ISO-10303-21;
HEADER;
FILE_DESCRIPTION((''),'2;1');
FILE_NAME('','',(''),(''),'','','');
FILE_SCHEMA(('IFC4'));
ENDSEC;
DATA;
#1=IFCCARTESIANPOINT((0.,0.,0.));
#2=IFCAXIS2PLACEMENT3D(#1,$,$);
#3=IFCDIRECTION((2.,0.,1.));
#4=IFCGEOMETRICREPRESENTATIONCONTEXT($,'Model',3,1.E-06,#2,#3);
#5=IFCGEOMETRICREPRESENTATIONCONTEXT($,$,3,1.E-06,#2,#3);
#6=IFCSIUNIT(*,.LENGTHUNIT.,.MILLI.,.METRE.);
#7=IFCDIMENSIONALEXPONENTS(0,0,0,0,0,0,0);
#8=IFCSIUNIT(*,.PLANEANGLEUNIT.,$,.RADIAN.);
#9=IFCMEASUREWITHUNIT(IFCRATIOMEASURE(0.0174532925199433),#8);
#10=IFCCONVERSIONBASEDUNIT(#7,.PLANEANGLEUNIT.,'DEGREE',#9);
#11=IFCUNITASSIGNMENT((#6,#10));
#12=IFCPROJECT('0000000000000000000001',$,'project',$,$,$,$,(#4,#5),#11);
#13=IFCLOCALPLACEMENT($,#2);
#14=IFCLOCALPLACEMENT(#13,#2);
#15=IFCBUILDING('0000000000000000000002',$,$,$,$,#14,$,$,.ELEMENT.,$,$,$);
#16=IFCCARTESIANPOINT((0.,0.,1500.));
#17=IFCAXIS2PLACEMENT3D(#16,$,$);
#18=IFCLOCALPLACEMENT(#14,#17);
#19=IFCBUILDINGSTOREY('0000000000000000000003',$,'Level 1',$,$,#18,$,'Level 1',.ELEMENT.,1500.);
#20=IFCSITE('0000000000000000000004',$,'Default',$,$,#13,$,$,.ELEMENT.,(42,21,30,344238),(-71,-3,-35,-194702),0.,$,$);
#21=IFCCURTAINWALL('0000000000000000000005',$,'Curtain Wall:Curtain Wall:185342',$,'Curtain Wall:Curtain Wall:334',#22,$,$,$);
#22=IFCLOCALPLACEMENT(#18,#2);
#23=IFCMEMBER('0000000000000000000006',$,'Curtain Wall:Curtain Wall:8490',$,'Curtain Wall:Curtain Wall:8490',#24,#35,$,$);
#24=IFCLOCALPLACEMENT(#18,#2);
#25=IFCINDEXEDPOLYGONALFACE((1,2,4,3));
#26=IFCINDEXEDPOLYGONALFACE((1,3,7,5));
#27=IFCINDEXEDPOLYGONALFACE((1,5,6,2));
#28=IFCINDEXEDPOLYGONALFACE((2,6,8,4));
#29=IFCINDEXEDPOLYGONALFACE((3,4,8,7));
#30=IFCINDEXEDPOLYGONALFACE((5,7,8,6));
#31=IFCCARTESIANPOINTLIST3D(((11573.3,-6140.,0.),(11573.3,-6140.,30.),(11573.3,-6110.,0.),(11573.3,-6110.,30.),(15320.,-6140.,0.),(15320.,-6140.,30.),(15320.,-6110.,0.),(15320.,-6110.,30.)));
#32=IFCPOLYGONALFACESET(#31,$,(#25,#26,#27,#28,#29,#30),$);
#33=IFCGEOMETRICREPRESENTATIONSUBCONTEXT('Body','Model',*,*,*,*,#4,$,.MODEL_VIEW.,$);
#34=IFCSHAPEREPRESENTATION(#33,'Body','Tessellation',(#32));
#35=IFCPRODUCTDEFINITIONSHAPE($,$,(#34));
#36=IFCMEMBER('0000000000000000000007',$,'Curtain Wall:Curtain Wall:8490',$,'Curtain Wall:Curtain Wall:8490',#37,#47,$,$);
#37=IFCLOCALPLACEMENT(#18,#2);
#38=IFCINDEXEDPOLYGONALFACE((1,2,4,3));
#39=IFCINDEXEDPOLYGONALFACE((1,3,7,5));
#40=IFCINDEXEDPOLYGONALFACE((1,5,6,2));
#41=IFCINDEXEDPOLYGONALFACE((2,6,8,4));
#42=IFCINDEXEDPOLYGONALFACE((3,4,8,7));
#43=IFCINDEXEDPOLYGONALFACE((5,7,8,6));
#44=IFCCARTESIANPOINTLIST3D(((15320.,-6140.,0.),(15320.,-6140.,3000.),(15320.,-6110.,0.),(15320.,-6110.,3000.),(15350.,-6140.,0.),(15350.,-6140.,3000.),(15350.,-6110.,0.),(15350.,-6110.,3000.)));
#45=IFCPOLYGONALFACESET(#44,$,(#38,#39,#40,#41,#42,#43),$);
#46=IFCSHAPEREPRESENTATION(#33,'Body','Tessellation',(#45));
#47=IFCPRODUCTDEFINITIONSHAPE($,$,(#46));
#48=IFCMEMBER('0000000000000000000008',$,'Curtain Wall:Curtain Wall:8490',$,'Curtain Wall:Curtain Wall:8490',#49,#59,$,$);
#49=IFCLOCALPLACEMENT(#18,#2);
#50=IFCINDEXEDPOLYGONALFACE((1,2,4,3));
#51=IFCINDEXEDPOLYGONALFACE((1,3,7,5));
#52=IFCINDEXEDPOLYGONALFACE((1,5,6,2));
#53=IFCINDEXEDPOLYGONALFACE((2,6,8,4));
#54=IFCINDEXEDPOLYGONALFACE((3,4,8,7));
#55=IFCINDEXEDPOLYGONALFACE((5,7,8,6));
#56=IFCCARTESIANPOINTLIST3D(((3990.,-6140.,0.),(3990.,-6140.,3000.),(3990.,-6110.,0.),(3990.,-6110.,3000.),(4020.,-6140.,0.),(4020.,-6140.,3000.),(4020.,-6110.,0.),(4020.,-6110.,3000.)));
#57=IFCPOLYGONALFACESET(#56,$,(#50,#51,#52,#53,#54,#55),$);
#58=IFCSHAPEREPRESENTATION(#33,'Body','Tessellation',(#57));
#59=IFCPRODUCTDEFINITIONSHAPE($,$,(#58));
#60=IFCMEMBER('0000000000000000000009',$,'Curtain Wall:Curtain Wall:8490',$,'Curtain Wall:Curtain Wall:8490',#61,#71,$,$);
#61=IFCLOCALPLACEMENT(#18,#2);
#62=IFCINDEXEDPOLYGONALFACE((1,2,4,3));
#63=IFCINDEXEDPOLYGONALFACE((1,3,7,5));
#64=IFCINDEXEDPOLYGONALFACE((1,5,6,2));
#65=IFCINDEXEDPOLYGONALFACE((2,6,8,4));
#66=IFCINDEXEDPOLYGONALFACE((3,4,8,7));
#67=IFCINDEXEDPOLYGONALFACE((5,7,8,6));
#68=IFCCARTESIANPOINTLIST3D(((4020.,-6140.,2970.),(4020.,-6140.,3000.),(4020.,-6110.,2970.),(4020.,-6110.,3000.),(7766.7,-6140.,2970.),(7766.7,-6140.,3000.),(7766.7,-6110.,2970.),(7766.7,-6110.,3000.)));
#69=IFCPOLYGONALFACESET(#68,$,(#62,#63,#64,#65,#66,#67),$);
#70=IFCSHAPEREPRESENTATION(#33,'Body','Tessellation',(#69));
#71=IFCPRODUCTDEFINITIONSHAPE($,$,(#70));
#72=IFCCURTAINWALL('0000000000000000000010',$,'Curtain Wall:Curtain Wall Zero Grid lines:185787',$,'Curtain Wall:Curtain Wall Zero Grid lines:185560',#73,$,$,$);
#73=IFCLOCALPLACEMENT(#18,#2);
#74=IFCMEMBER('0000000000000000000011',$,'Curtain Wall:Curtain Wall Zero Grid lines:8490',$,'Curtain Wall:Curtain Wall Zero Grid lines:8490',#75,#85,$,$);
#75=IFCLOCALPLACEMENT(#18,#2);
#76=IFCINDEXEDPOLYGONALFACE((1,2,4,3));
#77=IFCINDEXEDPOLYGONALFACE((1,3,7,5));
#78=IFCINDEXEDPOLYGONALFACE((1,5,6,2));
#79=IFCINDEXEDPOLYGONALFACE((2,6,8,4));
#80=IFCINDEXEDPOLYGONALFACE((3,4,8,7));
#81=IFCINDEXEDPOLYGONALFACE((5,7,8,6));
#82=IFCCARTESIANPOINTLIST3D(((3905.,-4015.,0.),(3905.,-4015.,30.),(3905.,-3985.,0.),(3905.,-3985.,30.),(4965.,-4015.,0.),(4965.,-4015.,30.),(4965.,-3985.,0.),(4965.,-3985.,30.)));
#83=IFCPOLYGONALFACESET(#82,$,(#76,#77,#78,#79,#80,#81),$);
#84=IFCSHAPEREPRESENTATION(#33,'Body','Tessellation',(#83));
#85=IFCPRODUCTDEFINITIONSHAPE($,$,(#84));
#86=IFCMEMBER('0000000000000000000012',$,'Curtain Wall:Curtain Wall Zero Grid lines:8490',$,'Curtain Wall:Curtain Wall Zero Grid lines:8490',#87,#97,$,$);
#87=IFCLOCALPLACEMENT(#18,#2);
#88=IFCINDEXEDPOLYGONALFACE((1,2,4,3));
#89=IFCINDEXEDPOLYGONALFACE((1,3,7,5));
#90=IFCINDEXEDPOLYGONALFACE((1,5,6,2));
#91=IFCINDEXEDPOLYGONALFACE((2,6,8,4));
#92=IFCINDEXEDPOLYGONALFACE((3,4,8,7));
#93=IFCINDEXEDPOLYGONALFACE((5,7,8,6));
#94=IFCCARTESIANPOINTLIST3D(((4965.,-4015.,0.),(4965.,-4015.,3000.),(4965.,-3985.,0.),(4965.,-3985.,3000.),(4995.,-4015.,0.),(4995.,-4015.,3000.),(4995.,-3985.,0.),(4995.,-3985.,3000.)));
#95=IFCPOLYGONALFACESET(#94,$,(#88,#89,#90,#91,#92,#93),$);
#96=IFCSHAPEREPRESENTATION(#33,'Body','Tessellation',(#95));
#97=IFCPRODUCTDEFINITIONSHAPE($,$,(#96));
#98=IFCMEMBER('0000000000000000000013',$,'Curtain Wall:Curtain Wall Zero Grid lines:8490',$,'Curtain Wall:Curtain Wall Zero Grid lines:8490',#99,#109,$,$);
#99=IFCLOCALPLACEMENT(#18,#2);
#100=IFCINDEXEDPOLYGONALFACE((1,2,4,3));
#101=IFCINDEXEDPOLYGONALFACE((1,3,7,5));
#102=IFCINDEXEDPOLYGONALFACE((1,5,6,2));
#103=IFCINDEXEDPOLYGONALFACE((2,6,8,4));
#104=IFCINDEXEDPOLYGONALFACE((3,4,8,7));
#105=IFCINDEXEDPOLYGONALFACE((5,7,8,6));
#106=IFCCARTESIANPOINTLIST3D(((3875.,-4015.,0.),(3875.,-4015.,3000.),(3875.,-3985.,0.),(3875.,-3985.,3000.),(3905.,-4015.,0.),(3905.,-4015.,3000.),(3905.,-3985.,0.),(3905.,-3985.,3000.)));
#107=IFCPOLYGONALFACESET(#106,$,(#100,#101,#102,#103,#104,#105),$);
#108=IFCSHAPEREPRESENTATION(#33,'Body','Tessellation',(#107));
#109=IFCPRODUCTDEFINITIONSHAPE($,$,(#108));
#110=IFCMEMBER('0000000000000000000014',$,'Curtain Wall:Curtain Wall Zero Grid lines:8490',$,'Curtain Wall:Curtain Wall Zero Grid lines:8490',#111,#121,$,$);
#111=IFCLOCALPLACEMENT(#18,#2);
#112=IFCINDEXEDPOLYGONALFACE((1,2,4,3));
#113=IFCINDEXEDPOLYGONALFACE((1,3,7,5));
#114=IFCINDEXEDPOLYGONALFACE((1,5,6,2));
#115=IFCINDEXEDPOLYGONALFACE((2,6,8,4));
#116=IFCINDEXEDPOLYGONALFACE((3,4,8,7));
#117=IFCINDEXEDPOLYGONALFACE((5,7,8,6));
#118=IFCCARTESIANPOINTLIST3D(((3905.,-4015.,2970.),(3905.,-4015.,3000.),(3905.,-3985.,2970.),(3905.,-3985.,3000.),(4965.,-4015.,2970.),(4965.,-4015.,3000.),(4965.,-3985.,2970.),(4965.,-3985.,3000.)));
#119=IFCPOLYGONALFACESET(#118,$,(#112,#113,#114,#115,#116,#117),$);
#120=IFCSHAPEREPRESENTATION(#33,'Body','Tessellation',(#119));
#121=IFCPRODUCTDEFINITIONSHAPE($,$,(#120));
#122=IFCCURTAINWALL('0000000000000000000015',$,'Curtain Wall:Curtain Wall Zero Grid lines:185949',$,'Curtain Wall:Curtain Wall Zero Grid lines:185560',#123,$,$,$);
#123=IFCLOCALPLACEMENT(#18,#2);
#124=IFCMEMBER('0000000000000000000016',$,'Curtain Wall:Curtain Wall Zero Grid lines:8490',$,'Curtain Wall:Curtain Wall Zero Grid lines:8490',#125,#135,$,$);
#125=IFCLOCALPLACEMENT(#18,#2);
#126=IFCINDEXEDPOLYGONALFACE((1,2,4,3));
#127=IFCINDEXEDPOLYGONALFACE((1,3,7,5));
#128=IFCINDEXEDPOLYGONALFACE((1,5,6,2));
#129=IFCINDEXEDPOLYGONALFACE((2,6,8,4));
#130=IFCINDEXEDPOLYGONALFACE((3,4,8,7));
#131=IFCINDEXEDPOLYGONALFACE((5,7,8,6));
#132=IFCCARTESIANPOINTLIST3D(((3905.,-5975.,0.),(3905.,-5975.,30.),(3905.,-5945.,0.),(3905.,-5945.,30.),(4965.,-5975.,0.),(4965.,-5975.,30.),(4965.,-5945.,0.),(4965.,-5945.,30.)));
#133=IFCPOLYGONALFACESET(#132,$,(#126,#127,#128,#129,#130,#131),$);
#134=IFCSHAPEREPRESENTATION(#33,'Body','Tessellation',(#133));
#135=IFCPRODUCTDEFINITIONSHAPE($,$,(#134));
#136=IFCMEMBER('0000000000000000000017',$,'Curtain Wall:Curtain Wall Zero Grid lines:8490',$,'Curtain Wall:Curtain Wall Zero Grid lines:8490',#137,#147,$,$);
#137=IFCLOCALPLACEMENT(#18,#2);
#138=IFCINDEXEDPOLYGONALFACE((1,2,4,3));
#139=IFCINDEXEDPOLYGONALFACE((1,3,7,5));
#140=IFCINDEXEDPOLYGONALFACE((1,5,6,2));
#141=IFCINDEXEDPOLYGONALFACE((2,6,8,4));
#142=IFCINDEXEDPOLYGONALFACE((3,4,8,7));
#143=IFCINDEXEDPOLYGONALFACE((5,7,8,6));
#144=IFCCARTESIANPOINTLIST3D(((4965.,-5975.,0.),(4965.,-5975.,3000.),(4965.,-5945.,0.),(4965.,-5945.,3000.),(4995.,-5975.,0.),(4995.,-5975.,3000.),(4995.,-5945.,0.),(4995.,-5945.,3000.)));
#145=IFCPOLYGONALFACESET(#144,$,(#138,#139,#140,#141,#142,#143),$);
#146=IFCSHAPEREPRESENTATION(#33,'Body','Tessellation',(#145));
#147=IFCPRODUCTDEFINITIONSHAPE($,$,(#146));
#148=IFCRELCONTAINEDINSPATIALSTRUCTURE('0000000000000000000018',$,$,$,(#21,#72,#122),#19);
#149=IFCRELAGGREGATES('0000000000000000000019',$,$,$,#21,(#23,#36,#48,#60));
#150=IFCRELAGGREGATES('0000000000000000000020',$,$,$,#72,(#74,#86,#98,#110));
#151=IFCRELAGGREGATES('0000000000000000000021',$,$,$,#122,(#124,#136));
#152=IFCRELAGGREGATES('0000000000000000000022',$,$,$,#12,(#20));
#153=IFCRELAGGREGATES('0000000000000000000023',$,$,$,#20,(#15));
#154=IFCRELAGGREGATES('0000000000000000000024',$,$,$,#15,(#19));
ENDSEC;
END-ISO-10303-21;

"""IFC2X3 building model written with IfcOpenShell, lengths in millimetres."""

from ifc_helpers import new_model, entity, si_unit, converted_unit, direction, frame, frame_2d, origin, place, context, subcontext, project, spatial, rectangle, extrude, element, aggregate, save


model = new_model("IFC2X3")

# Units and contexts
model_context = context("Model", 3, precision=1e-06, world=origin(), true_north=direction((2.0, 0.0, 1.0)))
context_of_model = context(None, 3, precision=1e-06, world=origin(), true_north=direction((2.0, 0.0, 1.0)))
body_context = subcontext(model_context, "Body", "Model", "MODEL_VIEW")
ifc_project = project(units=[si_unit("LENGTHUNIT", "METRE", prefix="MILLI"), converted_unit("PLANEANGLEUNIT", "DEGREE", entity("IfcRatioMeasure", 0.0174532925199433), si_unit("PLANEANGLEUNIT", "RADIAN"), dimensions=[0, 0, 0, 0, 0, 0, 0])], contexts=[model_context, context_of_model])

# Site, building, storey
site_placement = place(None, origin())
site = spatial("IfcSite", under=ifc_project, at=site_placement, Name="Default", CompositionType="ELEMENT", RefLatitude=(42, 21, 30, 344238), RefLongitude=(-71, -3, -35, -194702), RefElevation=0.0)
building_placement = place(site_placement, origin())
building = spatial("IfcBuilding", under=site, at=building_placement, CompositionType="ELEMENT")
storey_placement = place(building_placement, frame((0.0, 0.0, 1500.0)))
storey = spatial("IfcBuildingStorey", under=building, at=storey_placement, Name="Level 1", LongName="Level 1", CompositionType="ELEMENT", Elevation=1500.0)

# Curtain walls, members
curtain_wall_1_placement = place(storey_placement, origin())
curtain_wall_1 = element("IfcCurtainWall", 1, at=curtain_wall_1_placement, inside=storey, Name="Curtain Wall:Curtain Wall:185342", ObjectType="Curtain Wall:Curtain Wall:334")
member_1_placement = place(storey_placement, origin())
member_1 = element("IfcMember", 2, at=member_1_placement, Name="Curtain Wall:Curtain Wall:8490", ObjectType="Curtain Wall:Curtain Wall:8490", context=body_context, shape_type="SweptSolid", body=[
    extrude(rectangle(XDim=3746.7, YDim=30.0, at=frame_2d((0.0, 0.0), x_axis=(1.0, 0.0))), frame((13446.7, -6125.0, 0.0), z_axis=(0.0, 0.0, 1.0), x_axis=(-1.0, 0.0, 0.0)), (0.0, 0.0, 1.0), 30.0),
])
member_2_placement = place(storey_placement, origin())
member_2 = element("IfcMember", 3, at=member_2_placement, Name="Curtain Wall:Curtain Wall:8490", ObjectType="Curtain Wall:Curtain Wall:8490", context=body_context, shape_type="SweptSolid", body=[
    extrude(rectangle(XDim=30.0, YDim=30.0, at=frame_2d((0.0, 0.0), x_axis=(1.0, 0.0))), frame((15335.0, -6125.0, 0.0), z_axis=(0.0, 0.0, 1.0), x_axis=(-1.0, 0.0, 0.0)), (0.0, 0.0, 1.0), 3000.0),
])
member_3_placement = place(storey_placement, origin())
member_3 = element("IfcMember", 4, at=member_3_placement, Name="Curtain Wall:Curtain Wall:8490", ObjectType="Curtain Wall:Curtain Wall:8490", context=body_context, shape_type="SweptSolid", body=[
    extrude(rectangle(XDim=30.0, YDim=30.0, at=frame_2d((0.0, 0.0), x_axis=(1.0, 0.0))), frame((4005.0, -6125.0, 0.0), z_axis=(0.0, 0.0, 1.0), x_axis=(0.0, -1.0, 0.0)), (0.0, 0.0, 1.0), 3000.0),
])
member_4_placement = place(storey_placement, origin())
member_4 = element("IfcMember", 5, at=member_4_placement, Name="Curtain Wall:Curtain Wall:8490", ObjectType="Curtain Wall:Curtain Wall:8490", context=body_context, shape_type="SweptSolid", body=[
    extrude(rectangle(XDim=3746.7, YDim=30.0, at=frame_2d((0.0, 0.0), x_axis=(1.0, 0.0))), frame((5893.3, -6125.0, 2970.0)), (0.0, 0.0, 1.0), 30.0),
])
aggregate(curtain_wall_1, [member_1, member_2, member_3, member_4])
curtain_wall_2_placement = place(storey_placement, origin())
curtain_wall_2 = element("IfcCurtainWall", 6, at=curtain_wall_2_placement, inside=storey, Name="Curtain Wall:Curtain Wall Zero Grid lines:185787", ObjectType="Curtain Wall:Curtain Wall Zero Grid lines:185560")
member_5_placement = place(storey_placement, origin())
member_5 = element("IfcMember", 7, at=member_5_placement, Name="Curtain Wall:Curtain Wall Zero Grid lines:8490", ObjectType="Curtain Wall:Curtain Wall Zero Grid lines:8490", context=body_context, shape_type="SweptSolid", body=[
    extrude(rectangle(XDim=1060.0, YDim=30.0, at=frame_2d((0.0, 0.0), x_axis=(1.0, 0.0))), frame((4435.0, -4000.0, 0.0)), (0.0, 0.0, 1.0), 30.0),
])
member_6_placement = place(storey_placement, origin())
member_6 = element("IfcMember", 8, at=member_6_placement, Name="Curtain Wall:Curtain Wall Zero Grid lines:8490", ObjectType="Curtain Wall:Curtain Wall Zero Grid lines:8490", context=body_context, shape_type="SweptSolid", body=[
    extrude(rectangle(XDim=30.0, YDim=30.0, at=frame_2d((0.0, 0.0), x_axis=(1.0, 0.0))), frame((4980.0, -4000.0, 0.0), z_axis=(0.0, 0.0, 1.0), x_axis=(0.0, 1.0, 0.0)), (0.0, 0.0, 1.0), 3000.0),
])
member_7_placement = place(storey_placement, origin())
member_7 = element("IfcMember", 9, at=member_7_placement, Name="Curtain Wall:Curtain Wall Zero Grid lines:8490", ObjectType="Curtain Wall:Curtain Wall Zero Grid lines:8490", context=body_context, shape_type="SweptSolid", body=[
    extrude(rectangle(XDim=30.0, YDim=30.0, at=frame_2d((0.0, 0.0), x_axis=(1.0, 0.0))), frame((3890.0, -4000.0, 0.0)), (0.0, 0.0, 1.0), 3000.0),
])
member_8_placement = place(storey_placement, origin())
member_8 = element("IfcMember", 10, at=member_8_placement, Name="Curtain Wall:Curtain Wall Zero Grid lines:8490", ObjectType="Curtain Wall:Curtain Wall Zero Grid lines:8490", context=body_context, shape_type="SweptSolid", body=[
    extrude(rectangle(XDim=1060.0, YDim=30.0, at=frame_2d((0.0, 0.0), x_axis=(1.0, 0.0))), frame((4435.0, -4000.0, 2970.0), z_axis=(0.0, 0.0, 1.0), x_axis=(-1.0, 0.0, 0.0)), (0.0, 0.0, 1.0), 30.0),
])
aggregate(curtain_wall_2, [member_5, member_6, member_7, member_8])
curtain_wall_3_placement = place(storey_placement, origin())
curtain_wall_3 = element("IfcCurtainWall", 11, at=curtain_wall_3_placement, inside=storey, Name="Curtain Wall:Curtain Wall Zero Grid lines:185949", ObjectType="Curtain Wall:Curtain Wall Zero Grid lines:185560")
member_9_placement = place(storey_placement, origin())
member_9 = element("IfcMember", 12, at=member_9_placement, Name="Curtain Wall:Curtain Wall Zero Grid lines:8490", ObjectType="Curtain Wall:Curtain Wall Zero Grid lines:8490", context=body_context, shape_type="SweptSolid", body=[
    extrude(rectangle(XDim=1060.0, YDim=30.0, at=frame_2d((0.0, 0.0), x_axis=(1.0, 0.0))), frame((4435.0, -5960.0, 0.0)), (0.0, 0.0, 1.0), 30.0),
])
member_10_placement = place(storey_placement, origin())
member_10 = element("IfcMember", 13, at=member_10_placement, Name="Curtain Wall:Curtain Wall Zero Grid lines:8490", ObjectType="Curtain Wall:Curtain Wall Zero Grid lines:8490", context=body_context, shape_type="SweptSolid", body=[
    extrude(rectangle(XDim=30.0, YDim=30.0, at=frame_2d((0.0, 0.0), x_axis=(1.0, 0.0))), frame((4980.0, -5960.0, 0.0), z_axis=(0.0, 0.0, 1.0), x_axis=(0.0, 1.0, 0.0)), (0.0, 0.0, 1.0), 3000.0),
])
aggregate(curtain_wall_3, [member_9, member_10])

save(model, "model.ifc")
